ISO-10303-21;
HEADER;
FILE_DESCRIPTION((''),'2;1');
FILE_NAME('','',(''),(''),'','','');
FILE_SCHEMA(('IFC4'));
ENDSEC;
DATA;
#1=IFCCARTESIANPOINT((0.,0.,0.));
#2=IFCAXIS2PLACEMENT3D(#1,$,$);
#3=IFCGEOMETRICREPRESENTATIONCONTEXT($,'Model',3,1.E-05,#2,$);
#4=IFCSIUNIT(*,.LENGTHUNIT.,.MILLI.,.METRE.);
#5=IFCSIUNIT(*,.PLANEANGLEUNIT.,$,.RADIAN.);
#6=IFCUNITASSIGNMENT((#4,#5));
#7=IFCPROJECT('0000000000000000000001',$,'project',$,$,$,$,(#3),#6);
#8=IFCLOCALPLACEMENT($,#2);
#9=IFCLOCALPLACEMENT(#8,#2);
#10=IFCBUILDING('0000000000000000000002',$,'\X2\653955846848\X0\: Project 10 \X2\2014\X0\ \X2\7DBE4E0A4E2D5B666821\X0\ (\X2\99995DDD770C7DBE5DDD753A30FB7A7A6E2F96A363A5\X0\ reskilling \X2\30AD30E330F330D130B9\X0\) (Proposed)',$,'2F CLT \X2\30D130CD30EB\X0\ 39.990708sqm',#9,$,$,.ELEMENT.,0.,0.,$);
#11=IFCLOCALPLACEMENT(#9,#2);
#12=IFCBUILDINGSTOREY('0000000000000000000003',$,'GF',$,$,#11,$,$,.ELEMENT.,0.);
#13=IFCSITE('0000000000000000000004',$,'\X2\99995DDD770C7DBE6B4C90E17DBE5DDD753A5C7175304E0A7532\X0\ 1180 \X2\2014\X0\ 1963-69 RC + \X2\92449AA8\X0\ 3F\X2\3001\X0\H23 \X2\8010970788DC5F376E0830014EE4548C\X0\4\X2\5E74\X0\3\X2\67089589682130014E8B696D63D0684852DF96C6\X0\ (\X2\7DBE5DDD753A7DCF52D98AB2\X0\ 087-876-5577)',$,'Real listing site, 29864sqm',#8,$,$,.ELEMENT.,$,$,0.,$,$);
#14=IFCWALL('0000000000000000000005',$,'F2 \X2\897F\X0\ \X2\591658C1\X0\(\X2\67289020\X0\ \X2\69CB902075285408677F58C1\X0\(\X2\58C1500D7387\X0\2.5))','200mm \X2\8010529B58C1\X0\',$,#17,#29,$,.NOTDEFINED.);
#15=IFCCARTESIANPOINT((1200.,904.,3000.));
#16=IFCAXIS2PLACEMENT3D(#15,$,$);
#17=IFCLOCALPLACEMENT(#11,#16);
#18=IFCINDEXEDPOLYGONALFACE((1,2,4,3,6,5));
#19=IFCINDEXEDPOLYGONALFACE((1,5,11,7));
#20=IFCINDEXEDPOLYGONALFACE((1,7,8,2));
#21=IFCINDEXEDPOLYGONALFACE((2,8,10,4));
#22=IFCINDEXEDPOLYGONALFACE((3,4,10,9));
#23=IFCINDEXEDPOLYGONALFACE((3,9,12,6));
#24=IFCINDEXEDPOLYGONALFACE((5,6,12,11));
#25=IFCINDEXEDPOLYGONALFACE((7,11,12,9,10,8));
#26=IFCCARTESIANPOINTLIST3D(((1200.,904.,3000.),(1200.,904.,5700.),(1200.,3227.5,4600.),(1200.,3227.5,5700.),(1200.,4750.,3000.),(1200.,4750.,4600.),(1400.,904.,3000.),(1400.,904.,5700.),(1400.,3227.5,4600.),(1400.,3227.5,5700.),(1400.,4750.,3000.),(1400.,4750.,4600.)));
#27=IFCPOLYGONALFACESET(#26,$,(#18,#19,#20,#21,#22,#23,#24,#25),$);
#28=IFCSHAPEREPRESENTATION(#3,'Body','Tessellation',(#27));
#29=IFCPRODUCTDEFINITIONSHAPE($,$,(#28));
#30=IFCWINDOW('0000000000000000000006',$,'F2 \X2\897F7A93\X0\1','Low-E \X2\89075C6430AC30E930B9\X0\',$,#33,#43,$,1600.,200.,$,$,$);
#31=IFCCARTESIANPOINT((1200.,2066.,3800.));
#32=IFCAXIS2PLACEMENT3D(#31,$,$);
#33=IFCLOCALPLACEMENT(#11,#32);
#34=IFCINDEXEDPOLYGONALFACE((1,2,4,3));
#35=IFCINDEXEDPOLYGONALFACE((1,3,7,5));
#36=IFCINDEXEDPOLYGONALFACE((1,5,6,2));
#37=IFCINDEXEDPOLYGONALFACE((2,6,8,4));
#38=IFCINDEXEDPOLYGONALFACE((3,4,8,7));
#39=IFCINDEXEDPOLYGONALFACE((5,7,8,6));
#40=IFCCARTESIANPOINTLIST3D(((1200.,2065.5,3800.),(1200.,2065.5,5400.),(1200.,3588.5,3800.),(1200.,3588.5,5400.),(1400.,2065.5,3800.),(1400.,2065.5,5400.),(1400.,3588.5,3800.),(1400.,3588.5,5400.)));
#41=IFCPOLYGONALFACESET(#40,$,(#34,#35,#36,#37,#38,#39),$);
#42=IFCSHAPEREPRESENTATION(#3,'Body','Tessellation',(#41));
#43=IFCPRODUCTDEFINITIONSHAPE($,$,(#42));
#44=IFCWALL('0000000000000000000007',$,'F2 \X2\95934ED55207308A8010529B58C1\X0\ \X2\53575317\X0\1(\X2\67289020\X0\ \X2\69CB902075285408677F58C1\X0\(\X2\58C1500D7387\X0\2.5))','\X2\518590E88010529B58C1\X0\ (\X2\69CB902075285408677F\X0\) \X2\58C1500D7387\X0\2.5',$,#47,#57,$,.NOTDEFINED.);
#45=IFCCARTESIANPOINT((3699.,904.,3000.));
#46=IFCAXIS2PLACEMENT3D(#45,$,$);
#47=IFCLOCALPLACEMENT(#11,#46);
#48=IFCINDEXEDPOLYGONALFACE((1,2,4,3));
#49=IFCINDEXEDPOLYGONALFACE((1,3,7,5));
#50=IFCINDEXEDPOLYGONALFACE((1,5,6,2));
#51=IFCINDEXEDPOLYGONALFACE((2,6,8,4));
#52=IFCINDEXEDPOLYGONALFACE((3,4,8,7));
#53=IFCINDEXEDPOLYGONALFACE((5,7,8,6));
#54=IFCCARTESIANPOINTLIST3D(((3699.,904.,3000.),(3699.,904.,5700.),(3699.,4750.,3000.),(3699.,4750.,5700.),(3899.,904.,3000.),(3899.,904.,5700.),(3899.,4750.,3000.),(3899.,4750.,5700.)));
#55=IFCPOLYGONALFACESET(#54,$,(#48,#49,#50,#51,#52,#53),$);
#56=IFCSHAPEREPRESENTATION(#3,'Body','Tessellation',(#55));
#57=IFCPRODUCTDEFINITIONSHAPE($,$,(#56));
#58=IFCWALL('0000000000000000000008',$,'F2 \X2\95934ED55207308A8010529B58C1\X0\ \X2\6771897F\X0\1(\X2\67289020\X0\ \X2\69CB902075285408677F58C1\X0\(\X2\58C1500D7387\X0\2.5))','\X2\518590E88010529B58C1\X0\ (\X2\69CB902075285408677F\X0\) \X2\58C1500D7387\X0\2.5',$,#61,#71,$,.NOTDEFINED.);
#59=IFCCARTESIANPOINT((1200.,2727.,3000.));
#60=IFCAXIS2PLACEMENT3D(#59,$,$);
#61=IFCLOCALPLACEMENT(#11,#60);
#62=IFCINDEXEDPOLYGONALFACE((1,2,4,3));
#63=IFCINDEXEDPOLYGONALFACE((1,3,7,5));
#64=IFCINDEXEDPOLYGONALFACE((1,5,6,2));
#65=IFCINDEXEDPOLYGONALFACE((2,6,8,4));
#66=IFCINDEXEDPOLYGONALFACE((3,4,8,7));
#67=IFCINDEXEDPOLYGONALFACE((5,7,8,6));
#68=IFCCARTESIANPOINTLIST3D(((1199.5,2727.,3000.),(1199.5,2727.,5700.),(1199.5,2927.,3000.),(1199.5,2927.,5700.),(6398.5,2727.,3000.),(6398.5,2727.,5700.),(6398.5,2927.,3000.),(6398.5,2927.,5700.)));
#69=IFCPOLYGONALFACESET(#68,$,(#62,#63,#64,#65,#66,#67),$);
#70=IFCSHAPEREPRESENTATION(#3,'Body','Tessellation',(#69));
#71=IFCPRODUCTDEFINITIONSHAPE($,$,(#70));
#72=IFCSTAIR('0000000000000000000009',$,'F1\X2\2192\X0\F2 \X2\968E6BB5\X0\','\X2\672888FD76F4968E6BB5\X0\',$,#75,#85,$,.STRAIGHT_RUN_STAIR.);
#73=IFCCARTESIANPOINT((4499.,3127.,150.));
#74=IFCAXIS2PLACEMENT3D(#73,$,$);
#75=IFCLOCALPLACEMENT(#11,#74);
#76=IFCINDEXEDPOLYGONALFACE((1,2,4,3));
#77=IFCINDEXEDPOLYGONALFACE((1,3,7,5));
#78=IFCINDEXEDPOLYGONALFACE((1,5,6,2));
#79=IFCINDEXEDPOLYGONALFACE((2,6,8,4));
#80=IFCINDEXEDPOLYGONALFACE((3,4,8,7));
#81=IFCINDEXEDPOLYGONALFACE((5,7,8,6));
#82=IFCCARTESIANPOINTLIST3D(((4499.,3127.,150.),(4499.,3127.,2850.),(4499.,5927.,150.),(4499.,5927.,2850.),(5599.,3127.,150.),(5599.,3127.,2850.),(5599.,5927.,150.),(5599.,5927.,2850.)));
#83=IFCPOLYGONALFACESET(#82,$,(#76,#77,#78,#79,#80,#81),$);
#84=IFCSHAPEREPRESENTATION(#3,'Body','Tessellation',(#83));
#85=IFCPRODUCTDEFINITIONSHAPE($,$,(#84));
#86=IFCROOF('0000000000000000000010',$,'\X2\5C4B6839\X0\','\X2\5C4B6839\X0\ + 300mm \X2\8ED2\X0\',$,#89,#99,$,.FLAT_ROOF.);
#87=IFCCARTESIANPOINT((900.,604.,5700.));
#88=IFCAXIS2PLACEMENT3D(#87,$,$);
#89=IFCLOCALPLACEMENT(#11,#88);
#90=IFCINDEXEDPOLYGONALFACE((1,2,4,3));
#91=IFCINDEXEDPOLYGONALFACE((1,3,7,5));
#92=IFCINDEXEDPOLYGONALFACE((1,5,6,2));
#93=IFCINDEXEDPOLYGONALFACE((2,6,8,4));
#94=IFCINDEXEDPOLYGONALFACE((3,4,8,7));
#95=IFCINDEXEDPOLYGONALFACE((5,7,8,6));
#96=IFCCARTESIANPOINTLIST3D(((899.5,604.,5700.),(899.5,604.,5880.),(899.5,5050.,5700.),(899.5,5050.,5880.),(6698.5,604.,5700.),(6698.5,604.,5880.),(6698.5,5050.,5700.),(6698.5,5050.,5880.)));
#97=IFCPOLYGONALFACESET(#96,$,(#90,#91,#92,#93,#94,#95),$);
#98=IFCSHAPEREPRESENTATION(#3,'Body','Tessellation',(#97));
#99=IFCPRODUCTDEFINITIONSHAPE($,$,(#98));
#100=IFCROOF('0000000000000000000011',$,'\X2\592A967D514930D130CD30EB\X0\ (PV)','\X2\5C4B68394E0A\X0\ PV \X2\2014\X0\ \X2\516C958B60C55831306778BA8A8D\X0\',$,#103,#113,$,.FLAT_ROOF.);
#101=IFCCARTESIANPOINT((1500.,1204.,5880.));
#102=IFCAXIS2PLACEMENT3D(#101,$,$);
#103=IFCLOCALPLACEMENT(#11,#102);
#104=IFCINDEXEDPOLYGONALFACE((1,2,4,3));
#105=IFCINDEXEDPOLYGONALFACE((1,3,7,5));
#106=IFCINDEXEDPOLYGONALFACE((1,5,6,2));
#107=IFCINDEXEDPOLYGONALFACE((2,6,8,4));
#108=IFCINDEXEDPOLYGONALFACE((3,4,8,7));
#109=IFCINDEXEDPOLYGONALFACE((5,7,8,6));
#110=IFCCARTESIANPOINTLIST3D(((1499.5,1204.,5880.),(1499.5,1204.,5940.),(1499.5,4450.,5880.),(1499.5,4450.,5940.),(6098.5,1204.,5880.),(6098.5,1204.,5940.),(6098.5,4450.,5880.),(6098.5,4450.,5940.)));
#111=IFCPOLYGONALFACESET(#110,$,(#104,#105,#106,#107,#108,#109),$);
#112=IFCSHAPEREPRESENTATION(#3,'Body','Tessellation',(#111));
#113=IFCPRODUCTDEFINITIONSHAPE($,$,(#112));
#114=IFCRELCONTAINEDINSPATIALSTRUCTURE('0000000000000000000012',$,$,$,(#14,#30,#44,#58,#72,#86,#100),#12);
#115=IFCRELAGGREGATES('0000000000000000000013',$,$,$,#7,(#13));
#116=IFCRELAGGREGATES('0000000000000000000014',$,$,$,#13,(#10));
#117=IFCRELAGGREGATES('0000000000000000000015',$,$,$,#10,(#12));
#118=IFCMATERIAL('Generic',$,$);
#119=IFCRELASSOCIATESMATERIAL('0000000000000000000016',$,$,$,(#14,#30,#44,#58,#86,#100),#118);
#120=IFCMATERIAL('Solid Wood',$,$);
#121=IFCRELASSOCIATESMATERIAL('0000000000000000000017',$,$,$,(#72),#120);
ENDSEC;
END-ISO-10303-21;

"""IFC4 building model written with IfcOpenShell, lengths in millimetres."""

from ifc_helpers import new_model, si_unit, frame, frame_2d, origin, place, context, project, spatial, rectangle, extrude, material, element, fill, save


model = new_model("IFC4")

# Units and contexts
model_context = context("Model", 3, precision=1e-05, world=origin())
ifc_project = project(units=[si_unit("LENGTHUNIT", "METRE", prefix="MILLI"), si_unit("PLANEANGLEUNIT", "RADIAN")], contexts=[model_context])

# Site, building, storey
site_placement = place(None, origin())
site = spatial("IfcSite", under=ifc_project, at=site_placement, Name="香川県綾歌郡綾川町山田上甲 1180 — 1963-69 RC + 鉄骨 3F、H23 耐震補強済、令和4年3月閉校、事業提案募集 (綾川町総務課 087-876-5577)", ObjectType="Real listing site, 29864sqm", CompositionType="ELEMENT", RefElevation=0.0)
building_placement = place(site_placement, origin())
building = spatial("IfcBuilding", under=site, at=building_placement, Name="改善案: Project 10 — 綾上中学校 (香川県綾川町・空港隣接 reskilling キャンパス) (Proposed)", ObjectType="2F CLT パネル 39.990708sqm", CompositionType="ELEMENT", ElevationOfRefHeight=0.0, ElevationOfTerrain=0.0)
storey_placement = place(building_placement, origin())
storey = spatial("IfcBuildingStorey", under=building, at=storey_placement, Name="GF", CompositionType="ELEMENT", Elevation=0.0)

# Shared definitions
ifc_material_1 = material(Name="Generic")

# Shared definitions
ifc_material_2 = material(Name="Solid Wood")

# Wall, opening, window
wall_1_placement = place(storey_placement, frame((1200.0, 904.0, 3000.0)))
wall_1 = element("IfcWall", 1, at=wall_1_placement, inside=storey, material=ifc_material_1, Name="F2 西 外壁(木造 構造用合板壁(壁倍率2.5))", Description="200mm 耐力壁", PredefinedType="NOTDEFINED", context=model_context, shape_type="SweptSolid", body=[
    extrude(rectangle(XDim=200.0, YDim=3846.0, at=frame_2d((100.0, 1923.0))), frame((1200.0, 904.0, 3000.0)), (0.0, 0.0, 1.0), 2700.0),
])
opening_1_placement = place(storey_placement, frame((1200.0, 2066.0, 3800.0)))
opening_1 = element("IfcOpeningElement", 2, at=opening_1_placement, cuts=wall_1, PredefinedType="NOTDEFINED", context=model_context, shape_type="SweptSolid", body=[
    extrude(rectangle(XDim=200.0, YDim=1523.0, at=frame_2d((100.0, 761.0))), frame((1200.0, 2066.0, 3800.0)), (0.0, 0.0, 1.0), 1600.0),
])
window_1_placement = place(storey_placement, frame((1200.0, 2066.0, 3800.0)))
window_1 = element("IfcWindow", 3, at=window_1_placement, inside=storey, material=ifc_material_1, Name="F2 西窓1", Description="Low-E 複層ガラス", OverallHeight=1600.0, OverallWidth=200.0, context=model_context, shape_type="SweptSolid", body=[
    extrude(rectangle(XDim=200.0, YDim=1523.0, at=frame_2d((100.0, 761.0))), frame((1200.0, 2066.0, 3800.0)), (0.0, 0.0, 1.0), 1600.0),
])
fill(opening_1, window_1)

# Walls
wall_2_placement = place(storey_placement, frame((3699.0, 904.0, 3000.0)))
element("IfcWall", 4, at=wall_2_placement, inside=storey, material=ifc_material_1, Name="F2 間仕切り耐力壁 南北1(木造 構造用合板壁(壁倍率2.5))", Description="内部耐力壁 (構造用合板) 壁倍率2.5", PredefinedType="NOTDEFINED", context=model_context, shape_type="SweptSolid", body=[
    extrude(rectangle(XDim=200.0, YDim=3846.0, at=frame_2d((100.0, 1923.0))), frame((3699.0, 904.0, 3000.0)), (0.0, 0.0, 1.0), 2700.0),
])
wall_3_placement = place(storey_placement, frame((1200.0, 2727.0, 3000.0)))
element("IfcWall", 5, at=wall_3_placement, inside=storey, material=ifc_material_1, Name="F2 間仕切り耐力壁 東西1(木造 構造用合板壁(壁倍率2.5))", Description="内部耐力壁 (構造用合板) 壁倍率2.5", PredefinedType="NOTDEFINED", context=model_context, shape_type="SweptSolid", body=[
    extrude(rectangle(XDim=5199.0, YDim=200.0, at=frame_2d((2599.0, 100.0))), frame((1200.0, 2727.0, 3000.0)), (0.0, 0.0, 1.0), 2700.0),
])

# Stair
stair_placement = place(storey_placement, frame((4499.0, 3127.0, 150.0)))
element("IfcStair", 6, at=stair_placement, inside=storey, material=ifc_material_2, Name="F1→F2 階段", Description="木製直階段", PredefinedType="STRAIGHT_RUN_STAIR", context=model_context, shape_type="SweptSolid", body=[
    extrude(rectangle(XDim=1100.0, YDim=2800.0, at=frame_2d((550.0, 1400.0))), frame((4499.0, 3127.0, 150.0)), (0.0, 0.0, 1.0), 2700.0),
])

# Roofs
roof_1_placement = place(storey_placement, frame((900.0, 604.0, 5700.0)))
element("IfcRoof", 7, at=roof_1_placement, inside=storey, material=ifc_material_1, Name="屋根", Description="屋根 + 300mm 軒", PredefinedType="FLAT_ROOF", context=model_context, shape_type="SweptSolid", body=[
    extrude(rectangle(XDim=5799.0, YDim=4446.0, at=frame_2d((2899.0, 2223.0))), frame((900.0, 604.0, 5700.0)), (0.0, 0.0, 1.0), 180.0),
])
roof_2_placement = place(storey_placement, frame((1500.0, 1204.0, 5880.0)))
element("IfcRoof", 8, at=roof_2_placement, inside=storey, material=ifc_material_1, Name="太陽光パネル (PV)", Description="屋根上 PV — 公開情報で確認", PredefinedType="FLAT_ROOF", context=model_context, shape_type="SweptSolid", body=[
    extrude(rectangle(XDim=4599.0, YDim=3246.0, at=frame_2d((2299.0, 1623.0))), frame((1500.0, 1204.0, 5880.0)), (0.0, 0.0, 1.0), 60.0),
])

save(model, "model.ifc")
